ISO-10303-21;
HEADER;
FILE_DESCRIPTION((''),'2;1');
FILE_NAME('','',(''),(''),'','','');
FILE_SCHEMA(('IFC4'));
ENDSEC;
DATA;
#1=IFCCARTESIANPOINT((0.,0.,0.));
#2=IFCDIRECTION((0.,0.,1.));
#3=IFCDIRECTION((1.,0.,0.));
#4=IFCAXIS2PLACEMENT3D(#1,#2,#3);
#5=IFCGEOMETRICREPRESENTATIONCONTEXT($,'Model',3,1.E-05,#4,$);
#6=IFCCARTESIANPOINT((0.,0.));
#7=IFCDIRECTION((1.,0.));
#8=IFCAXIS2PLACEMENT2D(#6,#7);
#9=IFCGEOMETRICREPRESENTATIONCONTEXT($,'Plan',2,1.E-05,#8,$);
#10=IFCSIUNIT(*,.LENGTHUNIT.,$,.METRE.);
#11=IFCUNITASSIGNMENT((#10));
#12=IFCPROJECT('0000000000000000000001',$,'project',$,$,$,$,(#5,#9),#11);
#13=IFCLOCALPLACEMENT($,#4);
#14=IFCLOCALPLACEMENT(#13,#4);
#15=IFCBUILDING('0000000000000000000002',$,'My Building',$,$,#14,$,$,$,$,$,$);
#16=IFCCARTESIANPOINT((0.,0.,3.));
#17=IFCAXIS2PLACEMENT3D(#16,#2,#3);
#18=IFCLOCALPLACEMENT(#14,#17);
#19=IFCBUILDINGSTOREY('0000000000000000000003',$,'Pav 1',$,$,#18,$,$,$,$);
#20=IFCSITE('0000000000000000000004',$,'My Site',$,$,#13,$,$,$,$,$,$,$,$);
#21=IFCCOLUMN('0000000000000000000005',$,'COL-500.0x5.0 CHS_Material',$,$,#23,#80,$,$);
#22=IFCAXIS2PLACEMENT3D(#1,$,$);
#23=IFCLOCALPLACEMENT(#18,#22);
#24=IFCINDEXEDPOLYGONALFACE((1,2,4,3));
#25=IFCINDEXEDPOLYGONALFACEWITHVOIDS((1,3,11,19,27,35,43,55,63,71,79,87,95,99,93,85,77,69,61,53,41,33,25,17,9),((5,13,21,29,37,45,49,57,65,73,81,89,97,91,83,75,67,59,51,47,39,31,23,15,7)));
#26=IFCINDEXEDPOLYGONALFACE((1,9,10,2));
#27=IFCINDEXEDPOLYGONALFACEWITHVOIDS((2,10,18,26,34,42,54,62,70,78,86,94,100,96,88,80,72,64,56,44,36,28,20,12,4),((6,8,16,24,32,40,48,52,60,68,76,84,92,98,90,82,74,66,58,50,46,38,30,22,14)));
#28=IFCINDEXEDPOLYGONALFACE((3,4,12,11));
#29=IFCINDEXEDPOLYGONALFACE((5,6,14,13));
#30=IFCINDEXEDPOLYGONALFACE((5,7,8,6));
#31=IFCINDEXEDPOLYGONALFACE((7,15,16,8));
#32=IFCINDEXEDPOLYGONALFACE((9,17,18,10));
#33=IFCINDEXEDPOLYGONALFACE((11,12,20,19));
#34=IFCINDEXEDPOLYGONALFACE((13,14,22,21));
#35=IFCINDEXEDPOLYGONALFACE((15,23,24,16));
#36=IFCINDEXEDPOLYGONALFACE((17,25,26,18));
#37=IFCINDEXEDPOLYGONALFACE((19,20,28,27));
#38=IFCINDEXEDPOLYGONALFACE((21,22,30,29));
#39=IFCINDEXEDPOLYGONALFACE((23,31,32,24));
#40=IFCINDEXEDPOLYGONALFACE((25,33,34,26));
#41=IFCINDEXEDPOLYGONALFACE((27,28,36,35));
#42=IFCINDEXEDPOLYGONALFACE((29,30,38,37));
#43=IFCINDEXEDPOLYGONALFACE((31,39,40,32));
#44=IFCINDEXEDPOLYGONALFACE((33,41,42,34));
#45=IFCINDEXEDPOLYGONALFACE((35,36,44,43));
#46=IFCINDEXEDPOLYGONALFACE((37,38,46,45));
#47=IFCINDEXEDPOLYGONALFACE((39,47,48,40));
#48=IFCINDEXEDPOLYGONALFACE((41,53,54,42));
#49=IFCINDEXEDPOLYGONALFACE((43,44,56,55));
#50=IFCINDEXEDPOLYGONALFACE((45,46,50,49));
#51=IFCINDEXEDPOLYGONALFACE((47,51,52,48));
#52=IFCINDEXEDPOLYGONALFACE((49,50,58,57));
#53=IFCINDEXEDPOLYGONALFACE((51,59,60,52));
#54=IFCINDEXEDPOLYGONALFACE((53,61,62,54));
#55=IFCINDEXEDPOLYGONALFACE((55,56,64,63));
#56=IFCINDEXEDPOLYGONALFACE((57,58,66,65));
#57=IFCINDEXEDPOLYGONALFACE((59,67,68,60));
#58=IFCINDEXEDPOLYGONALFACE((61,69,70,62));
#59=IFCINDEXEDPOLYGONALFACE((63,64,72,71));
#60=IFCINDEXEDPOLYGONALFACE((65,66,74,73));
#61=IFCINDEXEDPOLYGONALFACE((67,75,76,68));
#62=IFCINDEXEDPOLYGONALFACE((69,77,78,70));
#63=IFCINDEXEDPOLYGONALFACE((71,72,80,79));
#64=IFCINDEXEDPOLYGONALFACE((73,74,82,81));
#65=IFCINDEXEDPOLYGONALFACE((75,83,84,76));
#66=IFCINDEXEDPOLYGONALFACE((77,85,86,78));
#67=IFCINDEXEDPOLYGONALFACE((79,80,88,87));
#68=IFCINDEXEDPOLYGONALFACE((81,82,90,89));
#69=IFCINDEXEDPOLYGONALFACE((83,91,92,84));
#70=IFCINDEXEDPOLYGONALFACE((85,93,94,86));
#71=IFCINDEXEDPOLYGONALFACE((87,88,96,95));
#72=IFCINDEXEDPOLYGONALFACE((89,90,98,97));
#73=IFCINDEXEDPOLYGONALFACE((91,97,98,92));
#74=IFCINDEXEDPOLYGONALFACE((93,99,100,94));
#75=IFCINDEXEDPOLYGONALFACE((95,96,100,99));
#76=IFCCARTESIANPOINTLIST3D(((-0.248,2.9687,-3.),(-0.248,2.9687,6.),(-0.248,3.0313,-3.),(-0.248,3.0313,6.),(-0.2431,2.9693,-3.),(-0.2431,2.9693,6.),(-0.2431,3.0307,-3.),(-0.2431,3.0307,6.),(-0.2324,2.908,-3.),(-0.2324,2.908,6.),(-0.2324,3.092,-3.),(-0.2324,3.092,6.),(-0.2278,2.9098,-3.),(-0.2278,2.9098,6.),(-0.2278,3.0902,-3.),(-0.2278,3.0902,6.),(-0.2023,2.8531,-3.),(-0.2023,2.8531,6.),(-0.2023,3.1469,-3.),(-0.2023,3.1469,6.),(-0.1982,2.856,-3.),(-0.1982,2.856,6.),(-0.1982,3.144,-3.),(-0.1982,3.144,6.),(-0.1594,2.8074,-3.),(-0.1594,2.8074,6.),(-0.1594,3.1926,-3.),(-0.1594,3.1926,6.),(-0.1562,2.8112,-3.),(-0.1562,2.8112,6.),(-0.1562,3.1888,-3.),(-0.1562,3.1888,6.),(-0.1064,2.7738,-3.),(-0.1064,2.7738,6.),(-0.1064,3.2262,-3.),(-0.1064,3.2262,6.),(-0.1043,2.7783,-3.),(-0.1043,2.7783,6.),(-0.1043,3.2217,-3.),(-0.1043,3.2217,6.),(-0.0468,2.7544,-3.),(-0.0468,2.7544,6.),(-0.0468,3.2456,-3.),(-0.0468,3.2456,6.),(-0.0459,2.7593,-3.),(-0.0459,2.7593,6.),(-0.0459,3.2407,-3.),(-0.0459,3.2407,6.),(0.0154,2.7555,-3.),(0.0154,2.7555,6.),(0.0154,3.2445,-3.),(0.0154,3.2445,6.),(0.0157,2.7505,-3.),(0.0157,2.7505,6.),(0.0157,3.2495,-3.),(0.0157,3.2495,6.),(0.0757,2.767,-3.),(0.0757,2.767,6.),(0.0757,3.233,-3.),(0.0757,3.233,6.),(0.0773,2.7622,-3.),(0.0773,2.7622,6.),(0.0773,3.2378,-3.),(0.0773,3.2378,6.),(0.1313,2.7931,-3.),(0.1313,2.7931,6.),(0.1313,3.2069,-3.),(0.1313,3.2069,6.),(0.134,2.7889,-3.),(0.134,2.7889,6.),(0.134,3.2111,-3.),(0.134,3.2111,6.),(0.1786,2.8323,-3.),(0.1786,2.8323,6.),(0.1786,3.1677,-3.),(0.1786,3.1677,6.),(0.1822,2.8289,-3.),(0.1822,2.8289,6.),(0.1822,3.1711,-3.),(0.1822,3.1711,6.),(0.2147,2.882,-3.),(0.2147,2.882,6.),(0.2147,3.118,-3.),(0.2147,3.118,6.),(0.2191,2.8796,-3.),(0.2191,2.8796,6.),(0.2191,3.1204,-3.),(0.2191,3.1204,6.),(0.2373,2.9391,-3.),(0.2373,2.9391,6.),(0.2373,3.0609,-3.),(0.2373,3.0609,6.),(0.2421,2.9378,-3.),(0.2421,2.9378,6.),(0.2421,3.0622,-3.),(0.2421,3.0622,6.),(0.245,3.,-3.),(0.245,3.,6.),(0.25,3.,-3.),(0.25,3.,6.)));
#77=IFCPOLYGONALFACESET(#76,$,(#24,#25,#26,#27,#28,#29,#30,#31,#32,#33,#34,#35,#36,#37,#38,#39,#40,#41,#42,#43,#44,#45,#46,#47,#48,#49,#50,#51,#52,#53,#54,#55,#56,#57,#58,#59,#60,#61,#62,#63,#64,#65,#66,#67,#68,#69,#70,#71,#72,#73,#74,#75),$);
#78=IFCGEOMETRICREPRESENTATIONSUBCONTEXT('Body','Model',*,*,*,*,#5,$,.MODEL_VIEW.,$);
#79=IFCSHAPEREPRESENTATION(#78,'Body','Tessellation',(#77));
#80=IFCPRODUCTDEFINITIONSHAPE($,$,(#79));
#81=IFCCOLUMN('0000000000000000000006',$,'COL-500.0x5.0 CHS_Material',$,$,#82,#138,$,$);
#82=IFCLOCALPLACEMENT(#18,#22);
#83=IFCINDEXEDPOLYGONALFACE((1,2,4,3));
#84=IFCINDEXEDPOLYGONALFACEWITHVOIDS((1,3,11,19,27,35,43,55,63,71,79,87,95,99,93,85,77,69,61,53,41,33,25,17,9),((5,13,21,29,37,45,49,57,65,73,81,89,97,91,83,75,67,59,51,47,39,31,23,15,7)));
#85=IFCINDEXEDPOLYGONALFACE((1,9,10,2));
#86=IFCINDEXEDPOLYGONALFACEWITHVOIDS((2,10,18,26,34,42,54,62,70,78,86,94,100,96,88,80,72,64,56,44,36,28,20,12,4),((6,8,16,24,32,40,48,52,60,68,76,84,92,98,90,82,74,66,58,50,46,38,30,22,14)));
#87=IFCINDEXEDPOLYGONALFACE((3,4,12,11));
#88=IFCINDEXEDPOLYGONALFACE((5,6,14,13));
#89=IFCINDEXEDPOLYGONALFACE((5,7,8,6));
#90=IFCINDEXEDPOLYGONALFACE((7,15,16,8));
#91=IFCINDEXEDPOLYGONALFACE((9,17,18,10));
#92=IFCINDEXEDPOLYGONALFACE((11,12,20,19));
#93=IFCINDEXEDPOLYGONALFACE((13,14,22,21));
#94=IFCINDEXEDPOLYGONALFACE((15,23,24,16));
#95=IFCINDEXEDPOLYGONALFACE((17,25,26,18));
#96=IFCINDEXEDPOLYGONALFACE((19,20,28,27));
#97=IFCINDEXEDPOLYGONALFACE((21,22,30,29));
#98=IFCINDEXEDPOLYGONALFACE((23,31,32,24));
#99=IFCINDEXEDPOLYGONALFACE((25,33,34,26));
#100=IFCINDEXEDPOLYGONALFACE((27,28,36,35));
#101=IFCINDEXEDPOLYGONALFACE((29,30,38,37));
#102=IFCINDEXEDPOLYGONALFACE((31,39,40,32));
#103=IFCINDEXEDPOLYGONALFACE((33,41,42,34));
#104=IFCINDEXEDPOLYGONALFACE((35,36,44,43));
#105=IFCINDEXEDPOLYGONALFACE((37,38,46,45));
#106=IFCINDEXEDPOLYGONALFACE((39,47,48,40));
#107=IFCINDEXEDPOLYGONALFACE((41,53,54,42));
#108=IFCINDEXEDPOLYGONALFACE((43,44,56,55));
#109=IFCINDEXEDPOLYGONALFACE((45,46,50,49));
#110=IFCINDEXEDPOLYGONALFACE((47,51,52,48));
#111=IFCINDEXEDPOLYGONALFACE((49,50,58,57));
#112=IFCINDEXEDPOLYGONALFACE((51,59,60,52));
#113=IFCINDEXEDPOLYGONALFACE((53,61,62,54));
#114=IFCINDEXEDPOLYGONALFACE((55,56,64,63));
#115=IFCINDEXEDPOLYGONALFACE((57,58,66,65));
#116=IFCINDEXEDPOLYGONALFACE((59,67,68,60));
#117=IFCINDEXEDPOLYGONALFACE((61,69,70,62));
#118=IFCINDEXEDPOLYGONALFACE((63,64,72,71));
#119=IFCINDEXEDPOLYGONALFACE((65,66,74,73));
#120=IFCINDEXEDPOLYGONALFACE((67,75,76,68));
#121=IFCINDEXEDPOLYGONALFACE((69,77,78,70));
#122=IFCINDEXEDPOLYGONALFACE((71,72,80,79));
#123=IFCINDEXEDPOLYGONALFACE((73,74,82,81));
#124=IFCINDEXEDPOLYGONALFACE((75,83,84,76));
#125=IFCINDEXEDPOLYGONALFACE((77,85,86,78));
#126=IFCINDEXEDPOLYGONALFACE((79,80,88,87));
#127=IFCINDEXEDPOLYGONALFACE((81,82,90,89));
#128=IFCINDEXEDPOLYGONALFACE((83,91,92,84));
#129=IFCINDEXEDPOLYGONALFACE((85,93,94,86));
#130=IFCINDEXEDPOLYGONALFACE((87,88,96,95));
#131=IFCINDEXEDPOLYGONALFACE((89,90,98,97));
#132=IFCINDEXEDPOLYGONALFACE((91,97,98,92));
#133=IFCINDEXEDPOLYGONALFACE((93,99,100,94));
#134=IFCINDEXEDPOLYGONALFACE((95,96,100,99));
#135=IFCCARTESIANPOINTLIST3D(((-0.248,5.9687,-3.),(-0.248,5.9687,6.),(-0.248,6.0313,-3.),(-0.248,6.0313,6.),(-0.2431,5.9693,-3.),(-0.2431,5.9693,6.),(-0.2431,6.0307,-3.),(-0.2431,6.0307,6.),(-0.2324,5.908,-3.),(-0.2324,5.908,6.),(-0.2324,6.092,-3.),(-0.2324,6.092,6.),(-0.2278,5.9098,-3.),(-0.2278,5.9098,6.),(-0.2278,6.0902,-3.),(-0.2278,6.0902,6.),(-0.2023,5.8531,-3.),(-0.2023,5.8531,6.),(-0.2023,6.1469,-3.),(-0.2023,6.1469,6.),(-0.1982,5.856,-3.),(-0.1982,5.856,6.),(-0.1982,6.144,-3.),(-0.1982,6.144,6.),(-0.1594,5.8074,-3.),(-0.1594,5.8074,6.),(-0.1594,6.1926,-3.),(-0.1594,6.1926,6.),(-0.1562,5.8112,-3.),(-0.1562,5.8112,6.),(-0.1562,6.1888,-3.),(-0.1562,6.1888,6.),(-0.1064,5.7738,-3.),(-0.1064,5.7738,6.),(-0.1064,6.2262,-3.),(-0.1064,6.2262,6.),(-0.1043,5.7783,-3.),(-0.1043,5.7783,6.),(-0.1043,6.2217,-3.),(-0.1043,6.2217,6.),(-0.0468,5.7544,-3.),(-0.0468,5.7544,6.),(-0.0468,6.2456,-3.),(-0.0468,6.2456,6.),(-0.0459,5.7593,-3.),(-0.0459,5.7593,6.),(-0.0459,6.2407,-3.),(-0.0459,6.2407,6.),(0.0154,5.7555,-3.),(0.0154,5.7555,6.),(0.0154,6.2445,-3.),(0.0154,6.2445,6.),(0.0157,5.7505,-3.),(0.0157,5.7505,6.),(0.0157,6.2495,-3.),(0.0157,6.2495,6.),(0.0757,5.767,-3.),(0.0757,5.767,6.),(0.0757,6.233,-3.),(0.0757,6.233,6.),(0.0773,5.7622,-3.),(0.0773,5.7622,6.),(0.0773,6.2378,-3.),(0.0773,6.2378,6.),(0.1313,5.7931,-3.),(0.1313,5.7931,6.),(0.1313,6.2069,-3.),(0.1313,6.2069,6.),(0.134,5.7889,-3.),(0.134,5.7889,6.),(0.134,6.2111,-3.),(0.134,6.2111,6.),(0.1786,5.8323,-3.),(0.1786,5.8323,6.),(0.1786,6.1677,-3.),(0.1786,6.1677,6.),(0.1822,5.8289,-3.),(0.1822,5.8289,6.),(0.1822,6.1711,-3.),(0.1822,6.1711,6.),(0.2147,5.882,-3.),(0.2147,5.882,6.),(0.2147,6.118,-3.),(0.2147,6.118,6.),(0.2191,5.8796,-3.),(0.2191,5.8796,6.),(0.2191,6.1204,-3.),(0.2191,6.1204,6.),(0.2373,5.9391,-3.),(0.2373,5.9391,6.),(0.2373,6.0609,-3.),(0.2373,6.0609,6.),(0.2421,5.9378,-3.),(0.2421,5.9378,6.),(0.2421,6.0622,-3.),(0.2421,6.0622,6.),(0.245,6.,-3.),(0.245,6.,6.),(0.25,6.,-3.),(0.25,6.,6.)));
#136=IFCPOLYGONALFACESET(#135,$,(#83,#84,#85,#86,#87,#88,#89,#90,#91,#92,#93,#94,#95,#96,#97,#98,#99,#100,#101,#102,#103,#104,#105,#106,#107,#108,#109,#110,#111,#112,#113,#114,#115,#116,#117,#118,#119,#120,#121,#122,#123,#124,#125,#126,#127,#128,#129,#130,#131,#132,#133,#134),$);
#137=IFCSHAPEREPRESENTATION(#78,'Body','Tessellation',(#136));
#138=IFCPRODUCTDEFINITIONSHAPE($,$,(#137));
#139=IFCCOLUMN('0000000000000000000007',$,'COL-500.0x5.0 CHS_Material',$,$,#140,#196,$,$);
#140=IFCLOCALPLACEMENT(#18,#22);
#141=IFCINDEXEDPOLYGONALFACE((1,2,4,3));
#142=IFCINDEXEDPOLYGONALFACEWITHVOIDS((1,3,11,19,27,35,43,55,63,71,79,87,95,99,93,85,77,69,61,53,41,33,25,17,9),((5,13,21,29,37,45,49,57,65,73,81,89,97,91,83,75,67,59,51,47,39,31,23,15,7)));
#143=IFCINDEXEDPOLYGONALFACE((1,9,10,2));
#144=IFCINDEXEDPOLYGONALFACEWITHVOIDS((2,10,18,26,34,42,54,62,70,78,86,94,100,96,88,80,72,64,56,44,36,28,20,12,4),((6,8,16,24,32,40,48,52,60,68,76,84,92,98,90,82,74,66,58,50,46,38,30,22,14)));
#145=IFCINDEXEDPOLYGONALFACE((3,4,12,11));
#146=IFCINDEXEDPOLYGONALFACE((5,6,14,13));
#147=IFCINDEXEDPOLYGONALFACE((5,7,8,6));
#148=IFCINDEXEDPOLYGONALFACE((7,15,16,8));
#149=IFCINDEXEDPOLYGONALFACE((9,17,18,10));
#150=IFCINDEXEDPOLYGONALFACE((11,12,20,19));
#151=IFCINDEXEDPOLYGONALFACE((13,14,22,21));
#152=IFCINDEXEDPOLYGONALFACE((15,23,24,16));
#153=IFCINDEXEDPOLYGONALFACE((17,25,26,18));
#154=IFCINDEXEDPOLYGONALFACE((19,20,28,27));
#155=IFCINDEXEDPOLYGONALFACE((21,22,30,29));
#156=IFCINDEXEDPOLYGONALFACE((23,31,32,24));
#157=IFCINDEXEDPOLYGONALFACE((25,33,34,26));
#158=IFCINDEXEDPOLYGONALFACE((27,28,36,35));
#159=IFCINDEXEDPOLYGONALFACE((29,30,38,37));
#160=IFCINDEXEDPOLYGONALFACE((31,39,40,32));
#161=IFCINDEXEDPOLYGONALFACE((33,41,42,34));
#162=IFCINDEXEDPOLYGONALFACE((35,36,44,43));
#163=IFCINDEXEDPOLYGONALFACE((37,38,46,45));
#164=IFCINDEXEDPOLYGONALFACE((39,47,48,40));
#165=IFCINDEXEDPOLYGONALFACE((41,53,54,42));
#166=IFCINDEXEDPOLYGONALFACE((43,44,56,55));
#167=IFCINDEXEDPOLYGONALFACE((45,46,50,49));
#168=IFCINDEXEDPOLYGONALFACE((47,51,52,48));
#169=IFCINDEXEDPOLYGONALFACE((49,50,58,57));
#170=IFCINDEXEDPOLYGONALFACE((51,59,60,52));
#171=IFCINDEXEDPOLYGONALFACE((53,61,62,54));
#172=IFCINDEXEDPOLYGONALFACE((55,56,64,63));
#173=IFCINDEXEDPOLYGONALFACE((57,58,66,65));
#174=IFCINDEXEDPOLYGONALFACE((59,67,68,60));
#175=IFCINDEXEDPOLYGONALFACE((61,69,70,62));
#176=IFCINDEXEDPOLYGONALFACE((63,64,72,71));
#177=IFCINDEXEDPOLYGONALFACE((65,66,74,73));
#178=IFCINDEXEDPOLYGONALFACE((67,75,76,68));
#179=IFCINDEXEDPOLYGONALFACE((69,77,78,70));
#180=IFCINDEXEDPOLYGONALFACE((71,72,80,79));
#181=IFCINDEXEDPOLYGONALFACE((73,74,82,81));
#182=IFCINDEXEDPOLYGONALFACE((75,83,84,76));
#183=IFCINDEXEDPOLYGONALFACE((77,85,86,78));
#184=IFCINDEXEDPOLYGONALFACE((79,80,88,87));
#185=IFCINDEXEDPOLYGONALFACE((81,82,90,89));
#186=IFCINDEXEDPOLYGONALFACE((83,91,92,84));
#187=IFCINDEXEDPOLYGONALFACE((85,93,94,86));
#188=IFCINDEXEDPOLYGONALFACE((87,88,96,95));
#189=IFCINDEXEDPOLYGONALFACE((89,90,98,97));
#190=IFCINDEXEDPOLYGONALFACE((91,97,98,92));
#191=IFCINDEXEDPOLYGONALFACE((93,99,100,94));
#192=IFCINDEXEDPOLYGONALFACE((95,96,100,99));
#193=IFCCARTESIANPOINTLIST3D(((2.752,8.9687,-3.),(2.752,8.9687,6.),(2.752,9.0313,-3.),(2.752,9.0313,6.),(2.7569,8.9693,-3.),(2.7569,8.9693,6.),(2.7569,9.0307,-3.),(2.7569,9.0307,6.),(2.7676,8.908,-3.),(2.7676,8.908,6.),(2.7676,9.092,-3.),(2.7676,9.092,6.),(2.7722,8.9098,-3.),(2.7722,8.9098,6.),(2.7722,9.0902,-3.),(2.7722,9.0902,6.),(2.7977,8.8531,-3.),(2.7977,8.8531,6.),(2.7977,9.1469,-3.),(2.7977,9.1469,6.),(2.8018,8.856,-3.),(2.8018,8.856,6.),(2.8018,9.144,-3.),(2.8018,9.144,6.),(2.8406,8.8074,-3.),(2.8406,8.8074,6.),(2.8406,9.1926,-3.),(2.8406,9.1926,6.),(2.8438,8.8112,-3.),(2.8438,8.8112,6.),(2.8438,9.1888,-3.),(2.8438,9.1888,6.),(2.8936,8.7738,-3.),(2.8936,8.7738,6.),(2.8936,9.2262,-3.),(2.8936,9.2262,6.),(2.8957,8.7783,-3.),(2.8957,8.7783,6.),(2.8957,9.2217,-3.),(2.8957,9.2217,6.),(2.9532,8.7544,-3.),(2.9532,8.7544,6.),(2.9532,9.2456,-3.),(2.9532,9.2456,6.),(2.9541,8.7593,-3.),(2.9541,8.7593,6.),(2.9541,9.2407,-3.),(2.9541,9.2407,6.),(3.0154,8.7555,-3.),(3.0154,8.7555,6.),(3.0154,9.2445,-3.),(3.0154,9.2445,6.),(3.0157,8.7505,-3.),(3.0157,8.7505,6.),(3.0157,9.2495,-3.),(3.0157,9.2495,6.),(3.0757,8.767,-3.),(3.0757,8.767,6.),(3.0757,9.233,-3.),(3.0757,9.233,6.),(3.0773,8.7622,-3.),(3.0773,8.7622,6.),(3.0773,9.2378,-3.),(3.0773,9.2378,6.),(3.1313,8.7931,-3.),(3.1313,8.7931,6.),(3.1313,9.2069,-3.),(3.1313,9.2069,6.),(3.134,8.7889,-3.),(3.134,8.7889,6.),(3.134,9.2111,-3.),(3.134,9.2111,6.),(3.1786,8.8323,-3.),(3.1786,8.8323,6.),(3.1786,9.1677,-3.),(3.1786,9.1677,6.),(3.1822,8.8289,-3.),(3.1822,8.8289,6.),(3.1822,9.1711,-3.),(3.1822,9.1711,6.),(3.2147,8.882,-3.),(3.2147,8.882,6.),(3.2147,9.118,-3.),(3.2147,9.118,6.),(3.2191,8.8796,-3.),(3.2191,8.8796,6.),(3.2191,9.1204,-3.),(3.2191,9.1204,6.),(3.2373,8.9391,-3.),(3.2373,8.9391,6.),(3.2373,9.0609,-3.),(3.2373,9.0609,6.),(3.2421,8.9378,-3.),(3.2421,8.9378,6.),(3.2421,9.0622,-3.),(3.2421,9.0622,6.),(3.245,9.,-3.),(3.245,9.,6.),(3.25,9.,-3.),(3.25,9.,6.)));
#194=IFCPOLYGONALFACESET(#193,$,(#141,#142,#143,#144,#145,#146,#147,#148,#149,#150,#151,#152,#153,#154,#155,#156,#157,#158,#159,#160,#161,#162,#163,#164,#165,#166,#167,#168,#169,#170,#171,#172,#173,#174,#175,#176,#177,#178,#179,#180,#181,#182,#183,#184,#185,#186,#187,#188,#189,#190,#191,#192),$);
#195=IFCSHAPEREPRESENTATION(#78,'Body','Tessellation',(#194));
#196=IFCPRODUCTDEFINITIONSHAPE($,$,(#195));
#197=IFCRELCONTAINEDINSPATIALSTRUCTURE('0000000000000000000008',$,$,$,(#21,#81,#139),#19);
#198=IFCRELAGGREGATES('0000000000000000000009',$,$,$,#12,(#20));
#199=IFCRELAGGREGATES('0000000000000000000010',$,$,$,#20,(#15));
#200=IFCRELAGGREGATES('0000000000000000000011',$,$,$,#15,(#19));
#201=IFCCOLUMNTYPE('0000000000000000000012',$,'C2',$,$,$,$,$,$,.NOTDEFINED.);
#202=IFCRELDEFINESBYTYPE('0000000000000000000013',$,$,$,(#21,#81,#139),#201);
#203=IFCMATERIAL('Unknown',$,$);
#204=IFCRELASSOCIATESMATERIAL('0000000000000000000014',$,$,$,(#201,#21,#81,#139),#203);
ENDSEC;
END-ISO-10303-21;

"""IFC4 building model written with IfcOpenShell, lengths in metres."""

from ifc_helpers import new_model, si_unit, frame, origin, origin_with_axes, origin_2d_with_axis, place, context, subcontext, project, spatial, hollow_circle, extrude, material, material_profile, profile_set, profile_usage, type_object, element, save


model = new_model("IFC4")

# Units and contexts
model_context = context("Model", 3, precision=1e-05, world=origin_with_axes())
plan_context = context("Plan", 2, precision=1e-05, world=origin_2d_with_axis())
body_context = subcontext(model_context, "Body", "Model", "MODEL_VIEW")
ifc_project = project(units=[si_unit("LENGTHUNIT", "METRE")], contexts=[model_context, plan_context])

# Site, building, storey
site_placement = place(None, origin_with_axes())
site = spatial("IfcSite", under=ifc_project, at=site_placement, Name="My Site")
building_placement = place(site_placement, origin_with_axes())
building = spatial("IfcBuilding", under=site, at=building_placement, Name="My Building")
storey_placement = place(building_placement, frame((0.0, 0.0, 3.0), z_axis=(0.0, 0.0, 1.0), x_axis=(1.0, 0.0, 0.0)))
storey = spatial("IfcBuildingStorey", under=building, at=storey_placement, Name="Pav 1")

# Columns
ifc_material = material(Name="Unknown")
ifc_material_profile = material_profile(ifc_material, hollow_circle(Radius=0.25, WallThickness=0.005))
ifc_profile_set = profile_set([ifc_material_profile])
column_type = type_object("IfcColumnType", Name="C2", PredefinedType="NOTDEFINED", material=ifc_profile_set)
ifc_profile_usage_1 = profile_usage(ifc_profile_set, cardinal=5)
column_1_placement = place(storey_placement, frame((0.0, 3.0, -3.0), z_axis=(0.0, 0.0, 1.0), x_axis=(1.0, 0.0, 0.0)))
element("IfcColumn", 1, at=column_1_placement, inside=storey, type_object=column_type, material=ifc_profile_usage_1, Name="COL-500.0x5.0 CHS_Material", context=body_context, shape_type="SweptSolid", body=[
    extrude(hollow_circle(Radius=0.25, WallThickness=0.005), origin(), (0.0, 0.0, 1.0), 9.0),
])
ifc_profile_usage_2 = profile_usage(ifc_profile_set, cardinal=5)
column_2_placement = place(storey_placement, frame((0.0, 6.0, -3.0), z_axis=(0.0, 0.0, 1.0), x_axis=(1.0, 0.0, 0.0)))
element("IfcColumn", 2, at=column_2_placement, inside=storey, type_object=column_type, material=ifc_profile_usage_2, Name="COL-500.0x5.0 CHS_Material", context=body_context, shape_type="SweptSolid", body=[
    extrude(hollow_circle(Radius=0.25, WallThickness=0.005), origin(), (0.0, 0.0, 1.0), 9.0),
])
ifc_profile_usage_3 = profile_usage(ifc_profile_set, cardinal=5)
column_3_placement = place(storey_placement, frame((3.0, 9.0, -3.0), z_axis=(0.0, 0.0, 1.0), x_axis=(1.0, 0.0, 0.0)))
element("IfcColumn", 3, at=column_3_placement, inside=storey, type_object=column_type, material=ifc_profile_usage_3, Name="COL-500.0x5.0 CHS_Material", context=body_context, shape_type="SweptSolid", body=[
    extrude(hollow_circle(Radius=0.25, WallThickness=0.005), origin(), (0.0, 0.0, 1.0), 9.0),
])

save(model, "model.ifc")
